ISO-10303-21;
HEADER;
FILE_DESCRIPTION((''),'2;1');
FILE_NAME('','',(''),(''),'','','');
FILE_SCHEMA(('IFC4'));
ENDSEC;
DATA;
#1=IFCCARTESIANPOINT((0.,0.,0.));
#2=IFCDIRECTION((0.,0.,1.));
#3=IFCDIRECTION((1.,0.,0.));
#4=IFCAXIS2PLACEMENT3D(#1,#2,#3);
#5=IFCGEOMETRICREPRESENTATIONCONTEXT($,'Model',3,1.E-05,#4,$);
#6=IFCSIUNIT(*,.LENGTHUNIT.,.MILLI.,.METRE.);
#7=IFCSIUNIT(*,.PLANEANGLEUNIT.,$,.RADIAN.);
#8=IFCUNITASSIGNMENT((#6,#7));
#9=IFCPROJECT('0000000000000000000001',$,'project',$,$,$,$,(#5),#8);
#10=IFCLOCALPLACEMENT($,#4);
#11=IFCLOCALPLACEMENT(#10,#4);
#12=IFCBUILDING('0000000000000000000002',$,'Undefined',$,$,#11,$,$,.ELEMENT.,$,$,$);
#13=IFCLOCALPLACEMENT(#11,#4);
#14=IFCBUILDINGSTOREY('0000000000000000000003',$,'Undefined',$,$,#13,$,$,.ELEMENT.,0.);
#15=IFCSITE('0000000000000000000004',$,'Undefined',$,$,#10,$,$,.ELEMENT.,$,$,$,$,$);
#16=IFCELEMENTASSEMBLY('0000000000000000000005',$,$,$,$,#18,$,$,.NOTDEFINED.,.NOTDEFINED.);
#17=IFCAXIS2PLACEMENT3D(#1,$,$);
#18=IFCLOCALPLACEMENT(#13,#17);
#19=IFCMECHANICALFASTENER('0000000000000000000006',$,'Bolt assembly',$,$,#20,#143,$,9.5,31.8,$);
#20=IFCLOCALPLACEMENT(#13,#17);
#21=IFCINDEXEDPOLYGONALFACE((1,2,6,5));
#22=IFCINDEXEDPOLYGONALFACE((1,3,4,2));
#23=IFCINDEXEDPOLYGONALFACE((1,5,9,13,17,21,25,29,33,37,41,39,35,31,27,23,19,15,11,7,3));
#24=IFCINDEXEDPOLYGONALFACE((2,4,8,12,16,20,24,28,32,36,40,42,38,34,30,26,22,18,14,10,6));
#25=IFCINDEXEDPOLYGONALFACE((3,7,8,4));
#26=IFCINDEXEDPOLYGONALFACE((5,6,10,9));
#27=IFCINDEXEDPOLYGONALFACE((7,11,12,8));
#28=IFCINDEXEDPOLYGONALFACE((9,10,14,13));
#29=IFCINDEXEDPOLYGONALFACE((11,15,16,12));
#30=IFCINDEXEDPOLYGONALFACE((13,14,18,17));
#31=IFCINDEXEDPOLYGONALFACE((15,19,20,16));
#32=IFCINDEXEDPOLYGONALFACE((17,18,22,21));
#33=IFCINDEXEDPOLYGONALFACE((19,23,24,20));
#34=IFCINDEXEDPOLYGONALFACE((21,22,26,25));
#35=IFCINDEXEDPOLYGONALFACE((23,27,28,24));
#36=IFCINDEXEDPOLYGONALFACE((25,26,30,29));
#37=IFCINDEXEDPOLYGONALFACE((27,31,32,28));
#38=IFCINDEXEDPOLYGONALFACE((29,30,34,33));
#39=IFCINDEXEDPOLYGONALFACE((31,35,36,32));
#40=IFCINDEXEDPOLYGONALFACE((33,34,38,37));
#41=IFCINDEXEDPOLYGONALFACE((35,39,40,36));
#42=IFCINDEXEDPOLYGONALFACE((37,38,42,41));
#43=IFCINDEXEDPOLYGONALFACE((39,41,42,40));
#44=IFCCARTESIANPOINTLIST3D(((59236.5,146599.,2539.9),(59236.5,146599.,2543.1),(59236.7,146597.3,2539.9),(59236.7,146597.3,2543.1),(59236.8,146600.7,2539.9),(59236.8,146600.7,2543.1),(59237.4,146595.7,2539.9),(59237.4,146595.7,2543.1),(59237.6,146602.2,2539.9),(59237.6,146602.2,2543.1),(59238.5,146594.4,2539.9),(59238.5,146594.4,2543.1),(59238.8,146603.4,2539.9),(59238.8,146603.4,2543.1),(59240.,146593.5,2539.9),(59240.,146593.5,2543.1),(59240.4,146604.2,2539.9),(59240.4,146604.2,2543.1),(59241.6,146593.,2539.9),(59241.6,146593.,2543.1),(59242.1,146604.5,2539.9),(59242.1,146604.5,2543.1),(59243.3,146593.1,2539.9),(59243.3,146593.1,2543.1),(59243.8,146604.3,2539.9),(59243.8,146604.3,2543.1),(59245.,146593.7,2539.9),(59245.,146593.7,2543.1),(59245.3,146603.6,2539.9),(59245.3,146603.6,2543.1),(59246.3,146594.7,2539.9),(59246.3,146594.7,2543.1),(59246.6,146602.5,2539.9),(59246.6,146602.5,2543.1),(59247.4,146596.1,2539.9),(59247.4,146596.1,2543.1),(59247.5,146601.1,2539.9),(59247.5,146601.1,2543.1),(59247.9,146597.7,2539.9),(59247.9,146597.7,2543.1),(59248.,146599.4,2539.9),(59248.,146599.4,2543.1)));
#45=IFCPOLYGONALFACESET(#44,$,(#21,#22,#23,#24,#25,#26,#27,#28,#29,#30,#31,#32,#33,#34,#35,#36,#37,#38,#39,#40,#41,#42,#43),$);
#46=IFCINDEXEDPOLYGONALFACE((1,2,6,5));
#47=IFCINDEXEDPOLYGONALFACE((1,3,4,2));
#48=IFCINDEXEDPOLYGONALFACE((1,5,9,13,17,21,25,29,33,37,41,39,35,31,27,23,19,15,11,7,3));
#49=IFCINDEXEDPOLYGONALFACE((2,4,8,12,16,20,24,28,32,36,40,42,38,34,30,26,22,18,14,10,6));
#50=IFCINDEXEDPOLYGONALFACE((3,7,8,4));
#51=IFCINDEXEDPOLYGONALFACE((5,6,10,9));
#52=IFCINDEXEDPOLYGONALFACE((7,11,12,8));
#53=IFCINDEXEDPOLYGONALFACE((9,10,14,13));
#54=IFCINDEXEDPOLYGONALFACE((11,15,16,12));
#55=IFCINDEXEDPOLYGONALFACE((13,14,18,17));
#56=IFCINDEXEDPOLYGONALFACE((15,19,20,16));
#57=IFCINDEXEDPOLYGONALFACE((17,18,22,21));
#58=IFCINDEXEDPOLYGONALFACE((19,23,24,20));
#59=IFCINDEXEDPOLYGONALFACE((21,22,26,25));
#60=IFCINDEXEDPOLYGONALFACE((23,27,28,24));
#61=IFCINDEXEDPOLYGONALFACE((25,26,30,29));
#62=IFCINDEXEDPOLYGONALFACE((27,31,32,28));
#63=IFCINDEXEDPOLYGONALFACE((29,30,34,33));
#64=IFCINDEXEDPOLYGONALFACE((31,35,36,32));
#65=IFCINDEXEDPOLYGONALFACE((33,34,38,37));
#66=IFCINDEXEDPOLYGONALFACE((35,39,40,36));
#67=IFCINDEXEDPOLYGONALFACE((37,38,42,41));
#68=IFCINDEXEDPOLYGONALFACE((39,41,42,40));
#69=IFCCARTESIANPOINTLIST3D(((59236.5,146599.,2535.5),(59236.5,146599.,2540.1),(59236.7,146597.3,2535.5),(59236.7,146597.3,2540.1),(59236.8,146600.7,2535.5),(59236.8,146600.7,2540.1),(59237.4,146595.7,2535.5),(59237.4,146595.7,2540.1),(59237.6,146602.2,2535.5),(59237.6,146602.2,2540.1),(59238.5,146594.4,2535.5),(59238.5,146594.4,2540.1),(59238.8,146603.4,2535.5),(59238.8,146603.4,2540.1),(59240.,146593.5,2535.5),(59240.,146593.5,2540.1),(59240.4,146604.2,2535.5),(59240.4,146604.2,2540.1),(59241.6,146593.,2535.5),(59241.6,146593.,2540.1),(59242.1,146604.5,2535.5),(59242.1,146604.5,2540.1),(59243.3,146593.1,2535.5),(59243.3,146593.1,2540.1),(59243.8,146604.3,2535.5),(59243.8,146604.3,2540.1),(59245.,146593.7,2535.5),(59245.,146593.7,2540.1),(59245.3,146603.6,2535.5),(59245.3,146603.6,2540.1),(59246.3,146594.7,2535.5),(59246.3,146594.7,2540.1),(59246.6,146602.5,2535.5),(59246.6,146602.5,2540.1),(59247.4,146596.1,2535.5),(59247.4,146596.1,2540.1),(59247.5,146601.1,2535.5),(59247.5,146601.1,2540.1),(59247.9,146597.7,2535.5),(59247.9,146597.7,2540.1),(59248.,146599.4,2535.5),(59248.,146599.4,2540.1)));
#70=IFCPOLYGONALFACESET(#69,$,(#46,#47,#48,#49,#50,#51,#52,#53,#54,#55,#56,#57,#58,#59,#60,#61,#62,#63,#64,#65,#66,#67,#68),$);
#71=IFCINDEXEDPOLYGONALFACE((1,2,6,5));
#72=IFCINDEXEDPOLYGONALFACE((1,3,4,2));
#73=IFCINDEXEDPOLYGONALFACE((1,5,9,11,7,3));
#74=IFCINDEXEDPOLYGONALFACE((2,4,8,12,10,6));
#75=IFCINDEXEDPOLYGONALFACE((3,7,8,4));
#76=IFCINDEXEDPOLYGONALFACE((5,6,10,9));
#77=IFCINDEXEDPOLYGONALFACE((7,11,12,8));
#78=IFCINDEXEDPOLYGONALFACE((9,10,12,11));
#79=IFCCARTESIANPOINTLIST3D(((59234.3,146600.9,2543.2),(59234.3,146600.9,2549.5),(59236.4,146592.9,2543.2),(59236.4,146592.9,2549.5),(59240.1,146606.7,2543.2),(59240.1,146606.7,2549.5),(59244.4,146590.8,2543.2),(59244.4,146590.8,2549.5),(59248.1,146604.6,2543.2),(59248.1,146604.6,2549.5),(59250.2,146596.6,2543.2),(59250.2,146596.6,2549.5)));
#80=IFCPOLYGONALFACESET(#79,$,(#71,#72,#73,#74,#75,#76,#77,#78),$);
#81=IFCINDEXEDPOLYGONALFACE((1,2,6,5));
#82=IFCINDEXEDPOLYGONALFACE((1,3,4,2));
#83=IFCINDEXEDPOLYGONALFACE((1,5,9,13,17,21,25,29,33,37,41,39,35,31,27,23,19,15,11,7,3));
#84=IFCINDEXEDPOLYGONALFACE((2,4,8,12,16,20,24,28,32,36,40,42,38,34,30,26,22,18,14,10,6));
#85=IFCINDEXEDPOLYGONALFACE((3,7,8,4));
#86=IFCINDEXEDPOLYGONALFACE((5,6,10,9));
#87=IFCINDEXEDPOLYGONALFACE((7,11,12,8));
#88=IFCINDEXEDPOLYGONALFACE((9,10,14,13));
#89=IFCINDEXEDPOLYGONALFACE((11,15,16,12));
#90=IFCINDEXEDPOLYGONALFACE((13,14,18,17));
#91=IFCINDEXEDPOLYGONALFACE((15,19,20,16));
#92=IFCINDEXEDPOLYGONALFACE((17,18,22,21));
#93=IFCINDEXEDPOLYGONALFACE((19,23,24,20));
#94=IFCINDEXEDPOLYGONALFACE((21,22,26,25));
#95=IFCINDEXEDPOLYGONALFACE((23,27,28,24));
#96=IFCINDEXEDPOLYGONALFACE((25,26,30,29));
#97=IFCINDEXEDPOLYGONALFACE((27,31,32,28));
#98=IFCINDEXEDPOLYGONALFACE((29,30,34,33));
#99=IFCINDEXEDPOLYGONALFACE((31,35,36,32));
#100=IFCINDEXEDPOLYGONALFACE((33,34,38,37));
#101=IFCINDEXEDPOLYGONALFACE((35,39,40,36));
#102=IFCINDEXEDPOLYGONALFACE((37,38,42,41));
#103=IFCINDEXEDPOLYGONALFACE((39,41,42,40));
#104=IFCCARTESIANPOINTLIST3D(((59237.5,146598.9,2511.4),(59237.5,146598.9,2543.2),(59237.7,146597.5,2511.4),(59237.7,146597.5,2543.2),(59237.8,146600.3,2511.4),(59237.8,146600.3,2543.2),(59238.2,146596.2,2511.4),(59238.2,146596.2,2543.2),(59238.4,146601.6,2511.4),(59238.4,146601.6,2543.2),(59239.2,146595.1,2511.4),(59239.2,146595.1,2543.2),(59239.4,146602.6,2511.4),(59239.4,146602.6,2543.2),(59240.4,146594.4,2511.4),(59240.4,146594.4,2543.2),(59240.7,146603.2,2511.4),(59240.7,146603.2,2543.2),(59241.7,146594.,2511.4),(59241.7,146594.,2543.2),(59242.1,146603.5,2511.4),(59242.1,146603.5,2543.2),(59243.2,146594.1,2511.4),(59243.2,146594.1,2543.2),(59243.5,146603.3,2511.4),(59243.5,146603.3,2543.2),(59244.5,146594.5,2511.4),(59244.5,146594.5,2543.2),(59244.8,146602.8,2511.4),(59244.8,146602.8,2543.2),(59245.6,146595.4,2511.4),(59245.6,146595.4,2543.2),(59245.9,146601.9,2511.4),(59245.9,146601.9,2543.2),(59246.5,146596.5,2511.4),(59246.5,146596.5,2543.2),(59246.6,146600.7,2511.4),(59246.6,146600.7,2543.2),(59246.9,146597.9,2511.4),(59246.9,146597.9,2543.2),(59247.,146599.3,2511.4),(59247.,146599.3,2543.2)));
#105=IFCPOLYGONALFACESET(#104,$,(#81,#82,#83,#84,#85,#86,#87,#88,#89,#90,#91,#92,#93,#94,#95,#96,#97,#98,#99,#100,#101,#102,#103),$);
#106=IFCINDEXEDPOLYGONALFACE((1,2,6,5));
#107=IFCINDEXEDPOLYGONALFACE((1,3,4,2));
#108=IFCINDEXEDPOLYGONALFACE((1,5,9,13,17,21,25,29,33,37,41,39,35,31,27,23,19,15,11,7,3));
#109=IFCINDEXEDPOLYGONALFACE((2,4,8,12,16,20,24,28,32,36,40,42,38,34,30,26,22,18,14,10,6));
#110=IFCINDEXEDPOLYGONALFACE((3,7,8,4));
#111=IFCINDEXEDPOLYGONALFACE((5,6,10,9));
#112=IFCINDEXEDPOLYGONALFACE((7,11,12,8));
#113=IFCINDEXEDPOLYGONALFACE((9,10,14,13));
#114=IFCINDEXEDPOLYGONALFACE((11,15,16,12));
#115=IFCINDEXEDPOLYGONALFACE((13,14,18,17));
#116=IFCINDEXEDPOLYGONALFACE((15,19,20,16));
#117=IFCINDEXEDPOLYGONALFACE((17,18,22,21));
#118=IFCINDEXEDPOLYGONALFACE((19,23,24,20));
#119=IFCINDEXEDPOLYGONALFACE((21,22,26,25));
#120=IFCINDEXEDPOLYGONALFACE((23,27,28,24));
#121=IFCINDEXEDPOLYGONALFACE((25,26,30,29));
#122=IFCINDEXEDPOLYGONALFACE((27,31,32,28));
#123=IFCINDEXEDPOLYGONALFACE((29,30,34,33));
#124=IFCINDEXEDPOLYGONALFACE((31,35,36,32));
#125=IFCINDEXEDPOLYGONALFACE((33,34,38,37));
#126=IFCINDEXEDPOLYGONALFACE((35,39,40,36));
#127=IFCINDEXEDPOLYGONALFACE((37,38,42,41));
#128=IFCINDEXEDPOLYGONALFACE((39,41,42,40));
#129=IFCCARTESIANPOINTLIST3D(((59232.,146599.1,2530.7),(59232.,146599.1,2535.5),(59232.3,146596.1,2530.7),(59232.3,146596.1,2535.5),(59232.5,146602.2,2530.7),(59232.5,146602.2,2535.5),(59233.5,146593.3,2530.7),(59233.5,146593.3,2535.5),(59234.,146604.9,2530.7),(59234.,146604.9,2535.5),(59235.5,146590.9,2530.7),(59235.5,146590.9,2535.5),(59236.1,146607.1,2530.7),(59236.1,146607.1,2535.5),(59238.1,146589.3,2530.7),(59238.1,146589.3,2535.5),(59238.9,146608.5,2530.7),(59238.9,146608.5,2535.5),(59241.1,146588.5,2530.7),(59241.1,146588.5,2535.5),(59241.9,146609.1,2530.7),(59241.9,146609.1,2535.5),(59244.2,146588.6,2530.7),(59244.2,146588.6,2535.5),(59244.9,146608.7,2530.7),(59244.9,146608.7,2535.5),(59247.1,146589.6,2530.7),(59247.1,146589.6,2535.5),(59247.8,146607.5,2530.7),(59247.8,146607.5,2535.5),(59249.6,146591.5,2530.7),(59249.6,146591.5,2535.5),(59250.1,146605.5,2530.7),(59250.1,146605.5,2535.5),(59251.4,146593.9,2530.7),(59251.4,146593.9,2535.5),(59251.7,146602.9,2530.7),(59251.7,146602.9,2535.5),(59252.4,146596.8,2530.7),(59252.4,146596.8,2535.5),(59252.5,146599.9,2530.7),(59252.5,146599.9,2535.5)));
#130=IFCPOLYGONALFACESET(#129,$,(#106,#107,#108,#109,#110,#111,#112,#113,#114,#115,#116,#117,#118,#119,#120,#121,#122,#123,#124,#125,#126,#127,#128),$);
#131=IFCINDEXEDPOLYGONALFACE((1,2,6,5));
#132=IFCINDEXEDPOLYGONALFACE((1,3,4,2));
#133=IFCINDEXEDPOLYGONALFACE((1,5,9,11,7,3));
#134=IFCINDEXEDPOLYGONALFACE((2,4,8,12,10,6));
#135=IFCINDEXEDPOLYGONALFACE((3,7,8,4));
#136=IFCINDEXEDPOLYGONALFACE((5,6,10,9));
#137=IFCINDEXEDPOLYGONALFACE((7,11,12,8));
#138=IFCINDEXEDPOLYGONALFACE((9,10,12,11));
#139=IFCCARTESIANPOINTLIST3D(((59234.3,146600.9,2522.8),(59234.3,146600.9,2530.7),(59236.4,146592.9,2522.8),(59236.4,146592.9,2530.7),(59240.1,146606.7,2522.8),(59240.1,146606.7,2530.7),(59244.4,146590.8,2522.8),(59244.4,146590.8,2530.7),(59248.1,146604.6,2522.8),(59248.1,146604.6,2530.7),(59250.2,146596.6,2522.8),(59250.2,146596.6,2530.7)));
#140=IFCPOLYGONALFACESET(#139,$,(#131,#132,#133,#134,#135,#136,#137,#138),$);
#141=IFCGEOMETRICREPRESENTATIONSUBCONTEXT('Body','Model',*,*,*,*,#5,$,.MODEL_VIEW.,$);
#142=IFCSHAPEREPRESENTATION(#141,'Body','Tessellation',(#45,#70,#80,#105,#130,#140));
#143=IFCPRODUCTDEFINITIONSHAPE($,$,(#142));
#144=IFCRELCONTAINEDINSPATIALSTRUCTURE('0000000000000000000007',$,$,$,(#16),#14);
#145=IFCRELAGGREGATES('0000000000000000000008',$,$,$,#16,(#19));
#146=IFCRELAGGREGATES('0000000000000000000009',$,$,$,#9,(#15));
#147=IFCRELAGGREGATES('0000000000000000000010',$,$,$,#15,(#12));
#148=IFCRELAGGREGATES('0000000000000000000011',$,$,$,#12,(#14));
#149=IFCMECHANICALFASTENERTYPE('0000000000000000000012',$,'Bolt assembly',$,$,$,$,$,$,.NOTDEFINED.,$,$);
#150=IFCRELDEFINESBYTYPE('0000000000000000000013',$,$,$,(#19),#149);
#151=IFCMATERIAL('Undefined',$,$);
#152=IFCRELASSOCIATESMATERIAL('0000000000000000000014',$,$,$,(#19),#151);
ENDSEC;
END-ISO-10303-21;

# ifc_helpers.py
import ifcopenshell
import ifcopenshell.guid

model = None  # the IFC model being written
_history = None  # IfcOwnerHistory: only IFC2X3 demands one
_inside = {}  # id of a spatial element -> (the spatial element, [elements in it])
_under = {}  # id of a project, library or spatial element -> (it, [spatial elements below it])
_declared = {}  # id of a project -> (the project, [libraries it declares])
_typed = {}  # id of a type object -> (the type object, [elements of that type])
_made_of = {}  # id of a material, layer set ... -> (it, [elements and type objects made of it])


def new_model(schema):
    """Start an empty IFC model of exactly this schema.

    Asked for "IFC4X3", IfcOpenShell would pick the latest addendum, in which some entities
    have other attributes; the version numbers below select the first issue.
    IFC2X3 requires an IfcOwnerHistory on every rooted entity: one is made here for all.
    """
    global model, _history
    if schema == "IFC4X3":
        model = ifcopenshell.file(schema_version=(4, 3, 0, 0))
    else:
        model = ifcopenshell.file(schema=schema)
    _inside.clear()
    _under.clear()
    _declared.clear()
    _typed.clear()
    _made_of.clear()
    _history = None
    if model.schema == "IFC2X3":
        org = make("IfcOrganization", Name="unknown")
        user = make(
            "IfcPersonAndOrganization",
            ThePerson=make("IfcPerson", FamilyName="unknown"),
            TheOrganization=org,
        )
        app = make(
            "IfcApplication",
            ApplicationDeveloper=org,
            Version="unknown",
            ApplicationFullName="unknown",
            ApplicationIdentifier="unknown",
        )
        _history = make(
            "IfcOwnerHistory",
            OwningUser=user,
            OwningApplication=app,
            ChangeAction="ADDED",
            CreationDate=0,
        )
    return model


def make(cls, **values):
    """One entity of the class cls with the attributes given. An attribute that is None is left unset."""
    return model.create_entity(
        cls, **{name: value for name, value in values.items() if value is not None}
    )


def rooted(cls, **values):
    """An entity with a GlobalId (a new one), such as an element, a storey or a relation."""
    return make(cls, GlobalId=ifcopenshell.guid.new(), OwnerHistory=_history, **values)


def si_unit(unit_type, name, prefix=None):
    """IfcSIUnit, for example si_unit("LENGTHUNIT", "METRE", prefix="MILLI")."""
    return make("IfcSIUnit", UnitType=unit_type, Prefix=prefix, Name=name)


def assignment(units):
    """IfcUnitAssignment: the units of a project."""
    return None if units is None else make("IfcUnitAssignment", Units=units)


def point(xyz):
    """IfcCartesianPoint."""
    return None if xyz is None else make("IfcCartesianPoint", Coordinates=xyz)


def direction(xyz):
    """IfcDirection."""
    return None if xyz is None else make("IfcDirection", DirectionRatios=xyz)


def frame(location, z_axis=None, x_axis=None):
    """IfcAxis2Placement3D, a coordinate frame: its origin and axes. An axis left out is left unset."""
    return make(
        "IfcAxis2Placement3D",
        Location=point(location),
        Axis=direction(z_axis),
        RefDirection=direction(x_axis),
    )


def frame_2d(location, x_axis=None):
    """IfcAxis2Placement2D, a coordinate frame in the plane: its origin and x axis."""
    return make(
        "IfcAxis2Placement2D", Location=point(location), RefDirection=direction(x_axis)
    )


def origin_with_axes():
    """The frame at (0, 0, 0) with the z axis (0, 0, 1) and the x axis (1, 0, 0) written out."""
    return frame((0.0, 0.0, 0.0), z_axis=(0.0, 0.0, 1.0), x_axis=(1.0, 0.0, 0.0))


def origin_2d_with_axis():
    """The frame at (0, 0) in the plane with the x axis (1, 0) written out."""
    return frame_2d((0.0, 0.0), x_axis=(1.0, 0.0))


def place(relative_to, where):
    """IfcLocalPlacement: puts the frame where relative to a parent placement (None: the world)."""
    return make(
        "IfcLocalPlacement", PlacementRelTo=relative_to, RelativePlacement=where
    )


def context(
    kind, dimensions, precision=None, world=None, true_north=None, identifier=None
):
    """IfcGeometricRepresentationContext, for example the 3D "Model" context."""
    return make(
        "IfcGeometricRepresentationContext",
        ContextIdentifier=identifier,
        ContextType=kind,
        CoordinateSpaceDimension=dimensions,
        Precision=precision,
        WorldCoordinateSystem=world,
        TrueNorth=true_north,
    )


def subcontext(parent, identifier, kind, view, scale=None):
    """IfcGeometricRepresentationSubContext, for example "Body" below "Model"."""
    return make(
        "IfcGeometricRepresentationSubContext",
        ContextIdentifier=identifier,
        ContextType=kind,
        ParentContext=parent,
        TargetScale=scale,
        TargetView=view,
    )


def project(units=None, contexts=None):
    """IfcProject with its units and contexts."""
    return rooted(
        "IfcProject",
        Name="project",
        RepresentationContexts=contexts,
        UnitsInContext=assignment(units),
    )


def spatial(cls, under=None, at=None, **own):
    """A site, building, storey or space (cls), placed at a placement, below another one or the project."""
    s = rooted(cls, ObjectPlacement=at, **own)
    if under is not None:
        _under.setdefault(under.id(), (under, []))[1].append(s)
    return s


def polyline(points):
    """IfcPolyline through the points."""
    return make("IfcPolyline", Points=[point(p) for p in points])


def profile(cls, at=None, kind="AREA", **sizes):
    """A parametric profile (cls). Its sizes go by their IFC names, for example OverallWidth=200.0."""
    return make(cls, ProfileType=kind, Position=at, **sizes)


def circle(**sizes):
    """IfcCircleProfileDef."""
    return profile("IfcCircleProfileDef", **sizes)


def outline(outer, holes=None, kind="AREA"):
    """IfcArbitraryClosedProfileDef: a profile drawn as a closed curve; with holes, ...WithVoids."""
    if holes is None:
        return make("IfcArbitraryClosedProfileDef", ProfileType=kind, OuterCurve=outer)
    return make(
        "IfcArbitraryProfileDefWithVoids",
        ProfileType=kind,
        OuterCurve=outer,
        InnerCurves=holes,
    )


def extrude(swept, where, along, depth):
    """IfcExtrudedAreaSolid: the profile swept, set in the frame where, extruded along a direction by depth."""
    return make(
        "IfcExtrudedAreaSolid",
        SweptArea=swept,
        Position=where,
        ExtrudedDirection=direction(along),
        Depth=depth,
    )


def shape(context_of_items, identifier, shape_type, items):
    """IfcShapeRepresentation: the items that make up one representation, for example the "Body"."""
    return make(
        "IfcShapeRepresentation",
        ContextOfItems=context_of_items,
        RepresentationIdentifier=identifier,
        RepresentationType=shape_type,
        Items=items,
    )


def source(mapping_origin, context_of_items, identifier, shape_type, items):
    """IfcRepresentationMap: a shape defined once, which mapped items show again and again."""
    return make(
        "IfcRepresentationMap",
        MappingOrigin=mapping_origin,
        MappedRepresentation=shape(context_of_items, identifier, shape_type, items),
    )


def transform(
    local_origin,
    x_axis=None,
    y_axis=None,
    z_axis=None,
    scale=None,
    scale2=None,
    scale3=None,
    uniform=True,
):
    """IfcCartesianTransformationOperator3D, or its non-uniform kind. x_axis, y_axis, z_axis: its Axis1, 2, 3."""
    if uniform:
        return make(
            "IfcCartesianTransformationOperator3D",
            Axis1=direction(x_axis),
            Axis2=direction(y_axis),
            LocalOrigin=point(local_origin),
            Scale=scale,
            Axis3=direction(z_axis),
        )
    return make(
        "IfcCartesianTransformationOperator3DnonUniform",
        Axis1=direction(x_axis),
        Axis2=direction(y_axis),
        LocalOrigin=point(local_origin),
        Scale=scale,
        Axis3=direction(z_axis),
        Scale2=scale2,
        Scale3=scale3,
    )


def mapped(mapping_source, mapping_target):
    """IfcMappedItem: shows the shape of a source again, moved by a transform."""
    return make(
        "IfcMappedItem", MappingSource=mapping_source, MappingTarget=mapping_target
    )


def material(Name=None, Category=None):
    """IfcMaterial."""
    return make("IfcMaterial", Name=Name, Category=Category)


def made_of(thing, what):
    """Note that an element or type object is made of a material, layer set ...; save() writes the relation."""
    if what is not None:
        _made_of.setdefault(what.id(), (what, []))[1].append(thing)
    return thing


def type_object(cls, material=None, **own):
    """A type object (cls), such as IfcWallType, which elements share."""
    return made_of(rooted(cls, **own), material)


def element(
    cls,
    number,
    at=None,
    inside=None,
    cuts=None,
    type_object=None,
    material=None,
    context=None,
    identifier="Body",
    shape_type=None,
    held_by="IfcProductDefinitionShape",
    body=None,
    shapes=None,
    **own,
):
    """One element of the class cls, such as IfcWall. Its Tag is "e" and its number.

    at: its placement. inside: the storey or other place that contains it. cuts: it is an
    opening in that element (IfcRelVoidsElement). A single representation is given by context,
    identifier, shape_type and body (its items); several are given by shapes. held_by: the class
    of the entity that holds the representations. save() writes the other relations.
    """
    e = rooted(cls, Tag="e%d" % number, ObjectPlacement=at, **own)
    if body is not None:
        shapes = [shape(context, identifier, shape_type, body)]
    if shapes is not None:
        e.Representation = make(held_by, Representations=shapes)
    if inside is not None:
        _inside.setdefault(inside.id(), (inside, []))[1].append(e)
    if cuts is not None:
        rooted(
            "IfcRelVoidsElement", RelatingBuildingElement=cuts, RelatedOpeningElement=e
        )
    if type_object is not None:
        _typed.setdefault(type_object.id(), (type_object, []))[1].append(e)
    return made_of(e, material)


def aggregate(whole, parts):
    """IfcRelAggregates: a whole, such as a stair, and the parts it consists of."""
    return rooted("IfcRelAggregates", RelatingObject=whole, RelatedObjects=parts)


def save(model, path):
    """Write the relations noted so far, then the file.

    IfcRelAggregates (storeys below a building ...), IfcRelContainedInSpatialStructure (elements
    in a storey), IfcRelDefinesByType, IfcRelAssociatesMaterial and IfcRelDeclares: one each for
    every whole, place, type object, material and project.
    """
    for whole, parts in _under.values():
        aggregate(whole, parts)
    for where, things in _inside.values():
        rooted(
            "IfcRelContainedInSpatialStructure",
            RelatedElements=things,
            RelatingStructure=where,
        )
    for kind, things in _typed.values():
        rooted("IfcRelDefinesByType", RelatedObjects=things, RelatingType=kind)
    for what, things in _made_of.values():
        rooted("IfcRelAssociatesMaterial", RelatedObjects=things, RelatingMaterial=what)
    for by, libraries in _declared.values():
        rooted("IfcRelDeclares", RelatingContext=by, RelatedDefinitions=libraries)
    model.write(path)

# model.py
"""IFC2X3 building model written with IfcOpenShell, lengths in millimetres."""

from ifc_helpers import new_model, si_unit, frame, origin_with_axes, origin_2d_with_axis, place, context, subcontext, project, spatial, polyline, circle, outline, extrude, source, transform, mapped, material, type_object, element, aggregate, save


model = new_model("IFC2X3")

# Units and contexts
model_context = context("Model", 3, precision=1e-05, world=origin_with_axes())
body_context = subcontext(model_context, "Body", "Model", "MODEL_VIEW")
ifc_project = project(units=[si_unit("LENGTHUNIT", "METRE", prefix="MILLI"), si_unit("PLANEANGLEUNIT", "RADIAN")], contexts=[model_context])

# Site, building, storey
site_placement = place(None, origin_with_axes())
site = spatial("IfcSite", under=ifc_project, at=site_placement, Name="Undefined", CompositionType="ELEMENT")
building_placement = place(site_placement, origin_with_axes())
building = spatial("IfcBuilding", under=site, at=building_placement, Name="Undefined", CompositionType="ELEMENT")
storey_placement = place(building_placement, origin_with_axes())
storey = spatial("IfcBuildingStorey", under=building, at=storey_placement, Name="Undefined", CompositionType="ELEMENT", Elevation=0.0)

# Element assembly
assembly_1_placement = place(storey_placement, origin_with_axes())
assembly_1 = element("IfcElementAssembly", 1, at=assembly_1_placement, inside=storey, AssemblyPlace="NOTDEFINED", PredefinedType="NOTDEFINED")

# Mechanical fastener
ifc_material_1 = material(Name="Undefined")
mechanical_fastener_type = type_object("IfcMechanicalFastenerType", Name="Bolt assembly")
shared_shape_1 = source(origin_with_axes(), body_context, "Body", "SweptSolid", [
    extrude(circle(Radius=5.8, at=origin_2d_with_axis()), frame((0.0, -7.6, 0.0), z_axis=(0.0, 1.0, 0.0), x_axis=(1.0, 0.0, 0.0)), (0.0, 0.0, 1.0), 3.2),
    extrude(circle(Radius=5.8, at=origin_2d_with_axis()), frame((0.0, -4.6, 0.0), z_axis=(0.0, 1.0, 0.0), x_axis=(1.0, 0.0, 0.0)), (0.0, 0.0, 1.0), 4.6),
    extrude(outline(polyline([(7.1, -4.1), (7.1, 4.1), (0.0, 8.2), (-7.1, 4.1), (-7.1, -4.1), (0.0, -8.2), (7.1, -4.1)])), frame((0.0, -14.0, 0.0), z_axis=(0.0, 1.0, 0.0), x_axis=(1.0, 0.0, 0.0)), (0.0, 0.0, 1.0), 6.3),
    extrude(circle(Radius=4.8, at=origin_2d_with_axis()), frame((0.0, -7.7, 0.0), z_axis=(0.0, 1.0, 0.0), x_axis=(1.0, 0.0, 0.0)), (0.0, 0.0, 1.0), 31.8),
    extrude(circle(Radius=10.3, at=origin_2d_with_axis()), frame((0.0, 0.0, 0.0), z_axis=(0.0, 1.0, 0.0), x_axis=(1.0, 0.0, 0.0)), (0.0, 0.0, 1.0), 4.8),
    extrude(outline(polyline([(7.1, -4.1), (7.1, 4.1), (0.0, 8.2), (-7.1, 4.1), (-7.1, -4.1), (0.0, -8.2), (7.1, -4.1)])), frame((0.0, 4.8, 0.0), z_axis=(0.0, 1.0, 0.0), x_axis=(1.0, 0.0, 0.0)), (0.0, 0.0, 1.0), 7.9),
])
mechanical_fastener_1_placement = place(assembly_1_placement, frame((59242.3, 146598.7, 2535.5), z_axis=(0.707107, 0.707107, 0.0), x_axis=(0.707107, -0.707107, 0.0)))
mechanical_fastener_1 = element("IfcMechanicalFastener", 2, at=mechanical_fastener_1_placement, type_object=mechanical_fastener_type, material=ifc_material_1, Name="Bolt assembly", NominalDiameter=9.5, NominalLength=31.8, context=body_context, shape_type="MappedRepresentation", body=[
    mapped(shared_shape_1, transform((0.0, 0.0, 0.0))),
])
aggregate(assembly_1, [mechanical_fastener_1])

save(model, "model.ifc")
